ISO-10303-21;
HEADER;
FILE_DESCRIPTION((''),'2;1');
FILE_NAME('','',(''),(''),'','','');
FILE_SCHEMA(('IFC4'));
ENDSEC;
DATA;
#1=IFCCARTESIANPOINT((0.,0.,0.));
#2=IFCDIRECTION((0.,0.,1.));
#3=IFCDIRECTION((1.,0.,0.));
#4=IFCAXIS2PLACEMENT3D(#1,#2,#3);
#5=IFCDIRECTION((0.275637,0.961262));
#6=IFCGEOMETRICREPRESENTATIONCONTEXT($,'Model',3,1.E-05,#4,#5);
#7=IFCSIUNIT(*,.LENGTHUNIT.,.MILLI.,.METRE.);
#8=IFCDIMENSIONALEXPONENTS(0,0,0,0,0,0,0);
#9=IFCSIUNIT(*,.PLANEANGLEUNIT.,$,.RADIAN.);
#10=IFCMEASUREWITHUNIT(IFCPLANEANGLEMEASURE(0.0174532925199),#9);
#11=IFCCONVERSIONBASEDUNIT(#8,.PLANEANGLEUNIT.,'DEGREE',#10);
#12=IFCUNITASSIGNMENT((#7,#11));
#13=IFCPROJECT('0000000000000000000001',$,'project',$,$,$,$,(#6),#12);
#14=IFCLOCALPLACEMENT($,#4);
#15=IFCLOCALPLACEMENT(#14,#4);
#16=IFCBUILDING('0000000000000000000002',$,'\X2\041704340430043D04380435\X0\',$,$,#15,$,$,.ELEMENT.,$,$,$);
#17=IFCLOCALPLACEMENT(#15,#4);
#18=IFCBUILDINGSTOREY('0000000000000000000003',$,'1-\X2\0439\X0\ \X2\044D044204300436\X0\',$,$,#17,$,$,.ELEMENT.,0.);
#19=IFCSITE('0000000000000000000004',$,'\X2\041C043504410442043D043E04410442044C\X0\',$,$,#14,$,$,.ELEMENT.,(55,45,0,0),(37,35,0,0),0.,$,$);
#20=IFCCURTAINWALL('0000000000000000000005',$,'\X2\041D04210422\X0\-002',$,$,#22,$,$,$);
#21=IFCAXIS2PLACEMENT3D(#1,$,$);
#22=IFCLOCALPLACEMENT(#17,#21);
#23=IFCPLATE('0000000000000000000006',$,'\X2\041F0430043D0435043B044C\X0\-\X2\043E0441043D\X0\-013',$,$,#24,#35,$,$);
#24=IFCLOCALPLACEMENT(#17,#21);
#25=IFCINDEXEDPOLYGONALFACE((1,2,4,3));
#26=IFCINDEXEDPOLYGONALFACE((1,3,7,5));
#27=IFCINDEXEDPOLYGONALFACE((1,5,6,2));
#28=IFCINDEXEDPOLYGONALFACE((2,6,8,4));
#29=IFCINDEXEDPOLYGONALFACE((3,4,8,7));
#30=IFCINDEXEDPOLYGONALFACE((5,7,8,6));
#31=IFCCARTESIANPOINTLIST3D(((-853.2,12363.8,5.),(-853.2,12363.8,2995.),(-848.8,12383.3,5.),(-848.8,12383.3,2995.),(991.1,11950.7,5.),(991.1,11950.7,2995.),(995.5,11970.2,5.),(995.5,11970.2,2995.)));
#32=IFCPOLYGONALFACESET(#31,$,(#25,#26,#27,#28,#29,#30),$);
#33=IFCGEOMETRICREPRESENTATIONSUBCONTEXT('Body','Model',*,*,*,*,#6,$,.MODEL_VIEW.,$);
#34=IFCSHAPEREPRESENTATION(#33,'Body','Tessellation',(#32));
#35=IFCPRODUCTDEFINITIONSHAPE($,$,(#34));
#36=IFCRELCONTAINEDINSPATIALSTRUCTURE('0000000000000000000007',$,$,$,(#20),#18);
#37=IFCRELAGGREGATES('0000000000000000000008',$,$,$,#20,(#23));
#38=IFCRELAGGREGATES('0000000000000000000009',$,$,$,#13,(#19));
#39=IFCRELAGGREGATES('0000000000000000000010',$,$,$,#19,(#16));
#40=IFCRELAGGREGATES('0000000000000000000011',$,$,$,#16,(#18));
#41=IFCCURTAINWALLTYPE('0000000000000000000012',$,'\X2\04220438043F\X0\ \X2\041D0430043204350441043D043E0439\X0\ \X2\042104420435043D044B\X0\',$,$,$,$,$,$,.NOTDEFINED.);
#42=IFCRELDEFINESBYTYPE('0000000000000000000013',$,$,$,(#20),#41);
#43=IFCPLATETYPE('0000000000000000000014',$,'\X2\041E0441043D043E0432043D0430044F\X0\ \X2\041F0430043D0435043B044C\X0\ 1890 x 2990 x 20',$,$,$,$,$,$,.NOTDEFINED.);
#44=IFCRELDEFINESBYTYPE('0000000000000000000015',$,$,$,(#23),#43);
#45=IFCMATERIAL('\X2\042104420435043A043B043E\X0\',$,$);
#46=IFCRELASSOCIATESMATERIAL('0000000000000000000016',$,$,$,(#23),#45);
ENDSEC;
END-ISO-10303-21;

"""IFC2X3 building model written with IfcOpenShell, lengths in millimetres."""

from ifc_helpers import new_model, entity, si_unit, converted_unit, direction, frame, origin_with_axes, place, context, subcontext, project, spatial, polyline, outline, extrude, material, type_object, element, aggregate, save


model = new_model("IFC2X3")

# Units and contexts
model_context = context("Model", 3, precision=1e-05, world=origin_with_axes(), true_north=direction((0.275637, 0.961262)))
body_context = subcontext(model_context, "Body", "Model", "MODEL_VIEW")
ifc_project = project(units=[si_unit("LENGTHUNIT", "METRE", prefix="MILLI"), converted_unit("PLANEANGLEUNIT", "DEGREE", entity("IfcPlaneAngleMeasure", 0.0174532925199), si_unit("PLANEANGLEUNIT", "RADIAN"), dimensions=[0, 0, 0, 0, 0, 0, 0])], contexts=[model_context])

# Site, building, storey
site_placement = place(None, origin_with_axes())
site = spatial("IfcSite", under=ifc_project, at=site_placement, Name="Местность", CompositionType="ELEMENT", RefLatitude=(55, 45, 0, 0), RefLongitude=(37, 35, 0, 0), RefElevation=0.0)
building_placement = place(site_placement, origin_with_axes())
building = spatial("IfcBuilding", under=site, at=building_placement, Name="Здание", CompositionType="ELEMENT")
storey_placement = place(building_placement, origin_with_axes())
storey = spatial("IfcBuildingStorey", under=building, at=storey_placement, Name="1-й этаж", CompositionType="ELEMENT", Elevation=0.0)

# Curtain wall, plate
curtain_wall_type = type_object("IfcCurtainWallType", Name="Тип Навесной Стены", PredefinedType="NOTDEFINED")
curtain_wall_placement = place(storey_placement, frame((71.2, 12167.0, -1000.0), z_axis=(0.0, 0.0, 1.0), x_axis=(1.0, 0.0, 0.0)))
curtain_wall = element("IfcCurtainWall", 1, at=curtain_wall_placement, inside=storey, type_object=curtain_wall_type, Name="НСТ-002")
ifc_material_1 = material(Name="Стекло")
plate_type_1 = type_object("IfcPlateType", Name="Основная Панель 1890 x 2990 x 20", PredefinedType="NOTDEFINED")
plate_1_placement = place(curtain_wall_placement, frame((0.0, 0.0, 2500.0), z_axis=(0.0, 0.0, 1.0), x_axis=(-0.975821, 0.218571, 0.0)))
plate_1 = element("IfcPlate", 2, at=plate_1_placement, type_object=plate_type_1, material=ifc_material_1, Name="Панель-осн-013", context=body_context, shape_type="SweptSolid", body=[
    extrude(outline(polyline([(-945.0, -1495.0), (945.0, -1495.0), (945.0, 1495.0), (-945.0, 1495.0), (-945.0, -1495.0)])), frame((0.0, -10.0, 0.0), z_axis=(0.0, 1.0, 0.0), x_axis=(1.0, 0.0, 0.0)), (0.0, 0.0, 1.0), 20.0),
])
aggregate(curtain_wall, [plate_1])

save(model, "model.ifc")
